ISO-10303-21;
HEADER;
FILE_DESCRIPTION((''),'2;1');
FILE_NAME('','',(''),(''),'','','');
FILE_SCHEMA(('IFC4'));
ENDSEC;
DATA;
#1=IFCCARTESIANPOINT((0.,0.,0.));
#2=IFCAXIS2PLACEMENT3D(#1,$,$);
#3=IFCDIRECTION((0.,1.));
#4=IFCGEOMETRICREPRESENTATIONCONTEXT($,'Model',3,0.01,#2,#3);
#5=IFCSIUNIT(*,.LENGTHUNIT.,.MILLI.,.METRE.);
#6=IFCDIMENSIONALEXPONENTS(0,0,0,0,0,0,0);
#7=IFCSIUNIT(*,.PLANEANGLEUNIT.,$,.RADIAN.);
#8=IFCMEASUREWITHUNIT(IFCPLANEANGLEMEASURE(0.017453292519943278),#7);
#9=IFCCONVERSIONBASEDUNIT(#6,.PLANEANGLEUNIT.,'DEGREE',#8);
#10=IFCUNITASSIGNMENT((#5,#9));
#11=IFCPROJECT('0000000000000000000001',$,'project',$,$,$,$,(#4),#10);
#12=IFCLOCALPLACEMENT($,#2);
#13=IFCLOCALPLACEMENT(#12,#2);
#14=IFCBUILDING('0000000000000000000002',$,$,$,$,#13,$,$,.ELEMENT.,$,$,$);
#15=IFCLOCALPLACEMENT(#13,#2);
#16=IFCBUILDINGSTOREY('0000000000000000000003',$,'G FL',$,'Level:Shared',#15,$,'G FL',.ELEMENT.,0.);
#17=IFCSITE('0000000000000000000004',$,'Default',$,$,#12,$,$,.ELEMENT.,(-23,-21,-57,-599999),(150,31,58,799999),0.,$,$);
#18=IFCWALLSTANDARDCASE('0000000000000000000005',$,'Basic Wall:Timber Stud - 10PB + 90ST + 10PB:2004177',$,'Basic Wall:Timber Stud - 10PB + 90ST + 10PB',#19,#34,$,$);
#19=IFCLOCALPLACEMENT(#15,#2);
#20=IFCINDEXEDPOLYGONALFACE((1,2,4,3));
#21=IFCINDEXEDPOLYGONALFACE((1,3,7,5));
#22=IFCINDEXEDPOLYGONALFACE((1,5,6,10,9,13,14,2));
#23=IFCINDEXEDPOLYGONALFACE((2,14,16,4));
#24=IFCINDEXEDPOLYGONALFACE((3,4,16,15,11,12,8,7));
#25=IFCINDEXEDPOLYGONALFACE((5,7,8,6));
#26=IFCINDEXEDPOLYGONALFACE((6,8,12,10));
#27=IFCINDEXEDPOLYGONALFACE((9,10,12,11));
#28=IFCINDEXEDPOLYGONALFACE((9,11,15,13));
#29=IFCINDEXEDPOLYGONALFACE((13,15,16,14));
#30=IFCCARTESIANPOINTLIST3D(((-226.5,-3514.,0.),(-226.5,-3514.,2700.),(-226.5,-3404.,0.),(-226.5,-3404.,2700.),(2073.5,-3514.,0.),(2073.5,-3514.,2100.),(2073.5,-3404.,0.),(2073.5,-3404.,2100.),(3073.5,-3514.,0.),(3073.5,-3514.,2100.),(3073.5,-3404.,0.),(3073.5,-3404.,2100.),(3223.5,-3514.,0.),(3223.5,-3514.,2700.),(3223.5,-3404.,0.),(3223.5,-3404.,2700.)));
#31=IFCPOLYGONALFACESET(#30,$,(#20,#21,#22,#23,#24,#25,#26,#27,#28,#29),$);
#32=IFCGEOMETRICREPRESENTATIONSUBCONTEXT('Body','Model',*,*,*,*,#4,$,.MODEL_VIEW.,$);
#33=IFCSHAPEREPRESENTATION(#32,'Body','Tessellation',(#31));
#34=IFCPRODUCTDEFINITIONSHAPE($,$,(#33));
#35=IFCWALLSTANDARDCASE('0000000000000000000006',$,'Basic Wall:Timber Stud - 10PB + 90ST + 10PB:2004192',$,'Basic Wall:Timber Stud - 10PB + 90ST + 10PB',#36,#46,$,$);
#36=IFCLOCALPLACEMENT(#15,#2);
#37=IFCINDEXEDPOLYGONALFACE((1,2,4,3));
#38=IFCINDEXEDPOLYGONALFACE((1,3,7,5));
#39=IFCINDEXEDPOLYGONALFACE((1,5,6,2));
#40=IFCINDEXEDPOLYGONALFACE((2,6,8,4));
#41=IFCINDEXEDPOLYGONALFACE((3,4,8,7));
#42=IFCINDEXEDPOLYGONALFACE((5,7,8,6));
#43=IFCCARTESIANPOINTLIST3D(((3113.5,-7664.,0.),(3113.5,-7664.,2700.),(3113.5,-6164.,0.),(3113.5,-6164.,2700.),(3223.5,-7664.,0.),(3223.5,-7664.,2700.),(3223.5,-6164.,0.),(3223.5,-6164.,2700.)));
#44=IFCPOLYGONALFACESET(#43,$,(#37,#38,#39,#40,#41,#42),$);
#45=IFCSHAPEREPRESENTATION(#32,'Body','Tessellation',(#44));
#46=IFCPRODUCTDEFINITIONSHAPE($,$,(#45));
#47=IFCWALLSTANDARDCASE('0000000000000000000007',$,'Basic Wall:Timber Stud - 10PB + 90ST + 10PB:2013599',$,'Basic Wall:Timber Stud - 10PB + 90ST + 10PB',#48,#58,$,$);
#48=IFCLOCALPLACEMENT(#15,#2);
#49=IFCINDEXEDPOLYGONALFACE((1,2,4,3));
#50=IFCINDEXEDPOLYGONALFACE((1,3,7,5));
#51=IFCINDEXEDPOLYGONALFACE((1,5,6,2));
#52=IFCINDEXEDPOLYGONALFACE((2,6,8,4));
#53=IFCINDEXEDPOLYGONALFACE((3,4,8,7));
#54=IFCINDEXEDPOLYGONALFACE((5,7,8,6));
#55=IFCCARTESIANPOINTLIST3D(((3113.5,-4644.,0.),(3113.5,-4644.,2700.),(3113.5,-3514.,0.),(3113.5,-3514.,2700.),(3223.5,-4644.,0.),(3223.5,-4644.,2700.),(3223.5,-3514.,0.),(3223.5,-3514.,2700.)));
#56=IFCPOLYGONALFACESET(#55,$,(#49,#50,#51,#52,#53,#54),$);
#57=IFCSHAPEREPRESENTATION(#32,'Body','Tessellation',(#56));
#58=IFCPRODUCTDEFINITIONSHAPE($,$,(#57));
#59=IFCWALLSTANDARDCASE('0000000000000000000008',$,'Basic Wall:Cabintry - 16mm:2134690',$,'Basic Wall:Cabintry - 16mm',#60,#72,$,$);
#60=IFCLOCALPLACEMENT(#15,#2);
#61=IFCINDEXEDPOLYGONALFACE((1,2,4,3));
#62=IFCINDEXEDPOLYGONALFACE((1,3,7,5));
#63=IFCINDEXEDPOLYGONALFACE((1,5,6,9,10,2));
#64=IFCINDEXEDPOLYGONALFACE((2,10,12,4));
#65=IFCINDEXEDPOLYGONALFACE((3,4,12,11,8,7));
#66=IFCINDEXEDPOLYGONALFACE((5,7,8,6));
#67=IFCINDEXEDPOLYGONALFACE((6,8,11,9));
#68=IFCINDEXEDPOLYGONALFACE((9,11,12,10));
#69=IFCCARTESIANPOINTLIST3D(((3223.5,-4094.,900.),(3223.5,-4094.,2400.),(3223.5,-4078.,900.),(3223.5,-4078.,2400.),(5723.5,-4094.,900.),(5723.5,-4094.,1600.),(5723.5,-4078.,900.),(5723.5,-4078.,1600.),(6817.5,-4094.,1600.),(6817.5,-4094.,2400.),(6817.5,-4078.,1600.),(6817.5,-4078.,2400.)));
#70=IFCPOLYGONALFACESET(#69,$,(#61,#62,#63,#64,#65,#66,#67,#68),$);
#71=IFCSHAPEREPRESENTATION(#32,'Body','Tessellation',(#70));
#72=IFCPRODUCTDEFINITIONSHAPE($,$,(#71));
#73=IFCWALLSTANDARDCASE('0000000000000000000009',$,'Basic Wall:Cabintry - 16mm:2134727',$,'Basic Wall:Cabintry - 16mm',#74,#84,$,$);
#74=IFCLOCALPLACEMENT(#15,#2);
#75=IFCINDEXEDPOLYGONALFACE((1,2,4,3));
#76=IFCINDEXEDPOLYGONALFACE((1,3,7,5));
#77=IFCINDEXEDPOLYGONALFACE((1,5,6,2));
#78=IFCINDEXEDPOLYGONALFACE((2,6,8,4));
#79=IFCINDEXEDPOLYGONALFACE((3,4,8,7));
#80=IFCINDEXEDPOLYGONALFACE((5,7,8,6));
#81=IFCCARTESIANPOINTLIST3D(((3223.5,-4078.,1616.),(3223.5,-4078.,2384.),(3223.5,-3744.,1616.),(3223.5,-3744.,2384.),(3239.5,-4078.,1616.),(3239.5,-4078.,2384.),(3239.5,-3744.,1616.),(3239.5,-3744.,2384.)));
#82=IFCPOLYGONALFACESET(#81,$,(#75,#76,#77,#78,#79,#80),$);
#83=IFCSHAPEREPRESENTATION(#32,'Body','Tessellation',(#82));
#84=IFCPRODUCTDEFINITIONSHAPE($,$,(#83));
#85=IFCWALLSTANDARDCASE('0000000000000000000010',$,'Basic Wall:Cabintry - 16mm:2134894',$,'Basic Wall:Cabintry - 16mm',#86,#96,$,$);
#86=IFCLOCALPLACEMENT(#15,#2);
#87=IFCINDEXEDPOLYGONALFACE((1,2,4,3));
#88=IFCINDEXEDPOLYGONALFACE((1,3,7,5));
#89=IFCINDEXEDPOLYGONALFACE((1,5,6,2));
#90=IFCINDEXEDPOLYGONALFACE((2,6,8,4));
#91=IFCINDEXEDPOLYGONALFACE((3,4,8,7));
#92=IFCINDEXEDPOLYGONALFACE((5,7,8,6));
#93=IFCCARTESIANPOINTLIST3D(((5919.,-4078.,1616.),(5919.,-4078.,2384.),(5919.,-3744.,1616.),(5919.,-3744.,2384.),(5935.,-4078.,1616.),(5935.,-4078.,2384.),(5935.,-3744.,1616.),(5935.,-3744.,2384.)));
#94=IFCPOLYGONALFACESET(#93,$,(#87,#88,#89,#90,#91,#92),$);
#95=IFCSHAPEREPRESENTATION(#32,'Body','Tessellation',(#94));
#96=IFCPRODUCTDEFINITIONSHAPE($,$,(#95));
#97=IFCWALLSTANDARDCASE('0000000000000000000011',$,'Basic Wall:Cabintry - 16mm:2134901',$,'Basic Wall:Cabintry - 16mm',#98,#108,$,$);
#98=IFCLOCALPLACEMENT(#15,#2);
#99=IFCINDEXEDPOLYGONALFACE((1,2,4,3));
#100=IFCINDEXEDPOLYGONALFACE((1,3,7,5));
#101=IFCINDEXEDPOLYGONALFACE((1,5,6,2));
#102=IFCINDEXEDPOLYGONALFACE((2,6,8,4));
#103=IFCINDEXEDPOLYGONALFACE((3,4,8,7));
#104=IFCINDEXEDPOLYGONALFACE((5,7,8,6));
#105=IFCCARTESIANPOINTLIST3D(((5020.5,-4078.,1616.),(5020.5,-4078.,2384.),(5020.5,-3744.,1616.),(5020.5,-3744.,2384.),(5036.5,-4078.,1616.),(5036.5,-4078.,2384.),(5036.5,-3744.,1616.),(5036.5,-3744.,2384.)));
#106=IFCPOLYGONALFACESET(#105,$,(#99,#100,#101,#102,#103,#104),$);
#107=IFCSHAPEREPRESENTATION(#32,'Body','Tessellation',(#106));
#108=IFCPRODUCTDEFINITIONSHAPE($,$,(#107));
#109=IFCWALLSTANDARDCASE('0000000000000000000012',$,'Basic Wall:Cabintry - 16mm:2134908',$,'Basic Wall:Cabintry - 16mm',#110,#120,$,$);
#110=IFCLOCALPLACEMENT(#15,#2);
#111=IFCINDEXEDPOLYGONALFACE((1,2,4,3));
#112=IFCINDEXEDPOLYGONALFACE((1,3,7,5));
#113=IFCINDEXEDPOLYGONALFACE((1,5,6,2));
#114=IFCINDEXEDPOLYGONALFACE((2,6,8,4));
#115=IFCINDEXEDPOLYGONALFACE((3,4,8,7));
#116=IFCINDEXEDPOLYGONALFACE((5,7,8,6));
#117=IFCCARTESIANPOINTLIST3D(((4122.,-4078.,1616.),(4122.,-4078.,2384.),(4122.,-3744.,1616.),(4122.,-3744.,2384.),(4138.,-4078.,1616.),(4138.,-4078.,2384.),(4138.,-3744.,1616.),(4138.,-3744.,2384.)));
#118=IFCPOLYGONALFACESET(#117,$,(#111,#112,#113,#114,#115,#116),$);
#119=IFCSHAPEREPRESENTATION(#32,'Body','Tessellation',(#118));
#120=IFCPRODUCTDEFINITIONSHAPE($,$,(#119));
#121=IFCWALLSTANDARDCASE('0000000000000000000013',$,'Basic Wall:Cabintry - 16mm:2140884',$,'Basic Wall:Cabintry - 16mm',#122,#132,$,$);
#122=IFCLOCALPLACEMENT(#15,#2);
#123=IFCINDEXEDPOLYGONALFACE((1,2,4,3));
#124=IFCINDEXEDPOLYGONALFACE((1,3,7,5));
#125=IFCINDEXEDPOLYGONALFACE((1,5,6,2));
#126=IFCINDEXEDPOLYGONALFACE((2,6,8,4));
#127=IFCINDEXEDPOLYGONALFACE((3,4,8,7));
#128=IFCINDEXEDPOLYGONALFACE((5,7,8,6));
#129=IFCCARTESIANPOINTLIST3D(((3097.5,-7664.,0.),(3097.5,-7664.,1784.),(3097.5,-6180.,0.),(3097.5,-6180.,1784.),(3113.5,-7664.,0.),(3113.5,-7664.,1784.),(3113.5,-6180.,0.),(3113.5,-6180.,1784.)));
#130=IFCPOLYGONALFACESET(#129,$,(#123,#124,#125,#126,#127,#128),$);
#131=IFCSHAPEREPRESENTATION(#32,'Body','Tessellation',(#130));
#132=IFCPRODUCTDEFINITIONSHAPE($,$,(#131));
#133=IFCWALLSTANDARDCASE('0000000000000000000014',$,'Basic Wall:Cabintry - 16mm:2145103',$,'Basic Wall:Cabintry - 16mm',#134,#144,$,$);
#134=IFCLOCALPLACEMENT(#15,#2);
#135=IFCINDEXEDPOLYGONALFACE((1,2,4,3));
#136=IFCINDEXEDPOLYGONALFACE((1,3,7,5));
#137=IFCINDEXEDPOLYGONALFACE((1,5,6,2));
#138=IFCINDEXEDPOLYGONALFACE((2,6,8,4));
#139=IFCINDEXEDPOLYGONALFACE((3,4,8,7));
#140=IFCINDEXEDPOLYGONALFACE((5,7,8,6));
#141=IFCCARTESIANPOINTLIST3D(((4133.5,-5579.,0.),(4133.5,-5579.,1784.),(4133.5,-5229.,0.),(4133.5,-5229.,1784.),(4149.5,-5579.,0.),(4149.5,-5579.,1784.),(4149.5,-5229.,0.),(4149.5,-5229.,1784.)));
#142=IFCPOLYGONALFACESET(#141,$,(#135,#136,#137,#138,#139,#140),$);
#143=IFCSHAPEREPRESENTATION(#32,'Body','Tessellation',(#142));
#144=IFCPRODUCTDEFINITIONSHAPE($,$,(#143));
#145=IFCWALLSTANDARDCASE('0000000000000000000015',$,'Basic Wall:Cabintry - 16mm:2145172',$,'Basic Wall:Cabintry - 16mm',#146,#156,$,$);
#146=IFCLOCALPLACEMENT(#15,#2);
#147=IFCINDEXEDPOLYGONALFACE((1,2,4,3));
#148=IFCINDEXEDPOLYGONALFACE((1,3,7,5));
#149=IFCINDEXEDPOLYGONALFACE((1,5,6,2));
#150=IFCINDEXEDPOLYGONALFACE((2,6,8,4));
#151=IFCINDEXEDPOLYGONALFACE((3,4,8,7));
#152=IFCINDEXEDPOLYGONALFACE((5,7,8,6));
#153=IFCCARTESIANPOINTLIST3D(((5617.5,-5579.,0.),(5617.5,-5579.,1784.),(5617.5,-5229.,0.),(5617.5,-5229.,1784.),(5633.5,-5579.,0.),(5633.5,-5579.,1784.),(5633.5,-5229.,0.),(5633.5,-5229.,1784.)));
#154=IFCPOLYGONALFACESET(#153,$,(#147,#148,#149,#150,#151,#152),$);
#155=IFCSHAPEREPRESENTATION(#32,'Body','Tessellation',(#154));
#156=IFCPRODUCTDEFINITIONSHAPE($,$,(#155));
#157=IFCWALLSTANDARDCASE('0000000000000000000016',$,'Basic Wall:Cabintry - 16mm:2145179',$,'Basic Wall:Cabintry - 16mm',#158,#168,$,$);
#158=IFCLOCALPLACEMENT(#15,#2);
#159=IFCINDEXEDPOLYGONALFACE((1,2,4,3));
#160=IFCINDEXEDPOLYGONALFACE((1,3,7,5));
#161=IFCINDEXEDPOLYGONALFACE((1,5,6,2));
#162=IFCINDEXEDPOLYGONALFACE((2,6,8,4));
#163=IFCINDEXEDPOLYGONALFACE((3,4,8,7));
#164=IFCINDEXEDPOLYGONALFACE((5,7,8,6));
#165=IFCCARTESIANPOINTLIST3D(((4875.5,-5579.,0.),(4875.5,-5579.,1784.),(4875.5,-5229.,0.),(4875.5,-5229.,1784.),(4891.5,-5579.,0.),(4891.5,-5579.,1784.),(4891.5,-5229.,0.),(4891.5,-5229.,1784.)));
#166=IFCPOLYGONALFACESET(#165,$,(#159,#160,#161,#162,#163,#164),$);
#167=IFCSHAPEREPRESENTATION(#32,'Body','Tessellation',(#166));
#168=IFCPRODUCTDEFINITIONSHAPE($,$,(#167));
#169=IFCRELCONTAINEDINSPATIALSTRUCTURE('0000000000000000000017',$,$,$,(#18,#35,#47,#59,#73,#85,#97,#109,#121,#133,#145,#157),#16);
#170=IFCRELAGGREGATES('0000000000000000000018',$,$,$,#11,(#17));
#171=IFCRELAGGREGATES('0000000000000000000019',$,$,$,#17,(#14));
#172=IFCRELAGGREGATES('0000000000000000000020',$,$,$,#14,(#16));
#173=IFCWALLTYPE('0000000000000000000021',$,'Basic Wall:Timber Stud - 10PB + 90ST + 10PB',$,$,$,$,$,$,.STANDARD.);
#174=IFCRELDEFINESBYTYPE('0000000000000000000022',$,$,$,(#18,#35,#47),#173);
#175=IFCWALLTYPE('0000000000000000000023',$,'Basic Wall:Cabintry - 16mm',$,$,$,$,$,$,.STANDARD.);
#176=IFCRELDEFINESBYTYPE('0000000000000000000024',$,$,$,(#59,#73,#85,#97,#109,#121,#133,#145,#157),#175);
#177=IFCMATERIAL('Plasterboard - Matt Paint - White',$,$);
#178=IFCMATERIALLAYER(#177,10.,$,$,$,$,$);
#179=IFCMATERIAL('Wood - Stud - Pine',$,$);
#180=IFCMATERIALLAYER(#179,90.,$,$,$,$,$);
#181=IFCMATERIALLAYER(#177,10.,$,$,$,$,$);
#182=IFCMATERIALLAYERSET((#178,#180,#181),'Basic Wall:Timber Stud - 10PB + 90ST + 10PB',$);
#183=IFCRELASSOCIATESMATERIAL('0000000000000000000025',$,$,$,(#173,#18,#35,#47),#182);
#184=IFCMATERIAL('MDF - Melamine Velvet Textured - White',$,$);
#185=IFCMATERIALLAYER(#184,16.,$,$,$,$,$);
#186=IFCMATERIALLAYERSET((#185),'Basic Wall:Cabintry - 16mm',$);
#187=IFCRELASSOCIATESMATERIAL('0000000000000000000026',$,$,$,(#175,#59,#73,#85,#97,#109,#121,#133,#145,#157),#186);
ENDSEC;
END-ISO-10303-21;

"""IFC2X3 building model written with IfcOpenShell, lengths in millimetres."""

from ifc_helpers import new_model, entity, si_unit, converted_unit, direction, frame, frame_2d, origin, place, context, subcontext, project, spatial, polyline, rectangle, extrude, clip, bounded_halfspace, material, layer, layer_set, layer_usage, type_object, element, save


model = new_model("IFC2X3")

# Units and contexts
model_context = context("Model", 3, precision=0.01, world=origin(), true_north=direction((0.0, 1.0)))
body_context = subcontext(model_context, "Body", "Model", "MODEL_VIEW")
ifc_project = project(units=[si_unit("LENGTHUNIT", "METRE", prefix="MILLI"), converted_unit("PLANEANGLEUNIT", "DEGREE", entity("IfcPlaneAngleMeasure", 0.017453292519943278), si_unit("PLANEANGLEUNIT", "RADIAN"), dimensions=[0, 0, 0, 0, 0, 0, 0])], contexts=[model_context])

# Site, building, storey
site_placement = place(None, origin())
site = spatial("IfcSite", under=ifc_project, at=site_placement, Name="Default", CompositionType="ELEMENT", RefLatitude=(-23, -21, -57, -599999), RefLongitude=(150, 31, 58, 799999), RefElevation=0.0)
building_placement = place(site_placement, origin())
building = spatial("IfcBuilding", under=site, at=building_placement, CompositionType="ELEMENT")
storey_placement = place(building_placement, origin())
storey = spatial("IfcBuildingStorey", under=building, at=storey_placement, Name="G FL", ObjectType="Level:Shared", LongName="G FL", CompositionType="ELEMENT", Elevation=0.0)

# Wall, opening
ifc_material_1 = material(Name="Plasterboard - Matt Paint - White")
ifc_layer_1 = layer(ifc_material_1, 10.0)
ifc_material_2 = material(Name="Wood - Stud - Pine")
ifc_layer_2 = layer(ifc_material_2, 90.0)
ifc_layer_3 = layer(ifc_material_1, 10.0)
ifc_layer_set_1 = layer_set([ifc_layer_1, ifc_layer_2, ifc_layer_3], Name="Basic Wall:Timber Stud - 10PB + 90ST + 10PB")
ifc_layer_usage_1 = layer_usage(ifc_layer_set_1, "AXIS2", "POSITIVE", -55.0)
wall_type_1 = type_object("IfcWallType", Name="Basic Wall:Timber Stud - 10PB + 90ST + 10PB", PredefinedType="STANDARD", material=ifc_layer_set_1)
wall_1_placement = place(storey_placement, frame((3223.5, -3459.0, 0.0), z_axis=(0.0, 0.0, 1.0), x_axis=(-1.0, 0.0, 0.0)))
wall_1 = element("IfcWallStandardCase", 1, at=wall_1_placement, inside=storey, type_object=wall_type_1, material=ifc_layer_usage_1, Name="Basic Wall:Timber Stud - 10PB + 90ST + 10PB:2004177", ObjectType="Basic Wall:Timber Stud - 10PB + 90ST + 10PB", context=body_context, shape_type="SweptSolid", body=[
    extrude(rectangle(XDim=3450.0, YDim=110.0, at=frame_2d((1725.0, 0.0), x_axis=(-1.0, 0.0))), origin(), (0.0, 0.0, 1.0), 2700.0),
])
opening_1_placement = place(wall_1_placement, frame((150.0, -55.0, 0.0)))
element("IfcOpeningElement", 2, at=opening_1_placement, cuts=wall_1, ObjectType="Opening", context=body_context, shape_type="SweptSolid", body=[
    extrude(rectangle(XDim=2100.0, YDim=1000.0, at=frame_2d((1050.0, 500.0), x_axis=(1.0, 0.0))), frame((0.0, 0.0, 0.0), z_axis=(0.0, 1.0, 0.0), x_axis=(0.0, 0.0, 1.0)), (0.0, 0.0, 1.0), 110.0),
])

# Walls
ifc_layer_usage_2 = layer_usage(ifc_layer_set_1, "AXIS2", "NEGATIVE", 55.0)
wall_2_placement = place(storey_placement, frame((3168.5, -6164.0, 0.0), z_axis=(0.0, 0.0, 1.0), x_axis=(0.0, -1.0, 0.0)))
element("IfcWallStandardCase", 3, at=wall_2_placement, inside=storey, type_object=wall_type_1, material=ifc_layer_usage_2, Name="Basic Wall:Timber Stud - 10PB + 90ST + 10PB:2004192", ObjectType="Basic Wall:Timber Stud - 10PB + 90ST + 10PB", context=body_context, shape_type="SweptSolid", body=[
    extrude(rectangle(XDim=1500.0, YDim=110.0, at=frame_2d((750.0, 0.0), x_axis=(-1.0, 0.0))), origin(), (0.0, 0.0, 1.0), 2700.0),
])
ifc_layer_usage_3 = layer_usage(ifc_layer_set_1, "AXIS2", "POSITIVE", -55.0)
wall_3_placement = place(storey_placement, frame((3168.5, -4644.0, 0.0), z_axis=(0.0, 0.0, 1.0), x_axis=(0.0, 1.0, 0.0)))
element("IfcWallStandardCase", 4, at=wall_3_placement, inside=storey, type_object=wall_type_1, material=ifc_layer_usage_3, Name="Basic Wall:Timber Stud - 10PB + 90ST + 10PB:2013599", ObjectType="Basic Wall:Timber Stud - 10PB + 90ST + 10PB", context=body_context, shape_type="SweptSolid", body=[
    extrude(rectangle(XDim=1130.0, YDim=110.0, at=frame_2d((565.0, 0.0), x_axis=(-1.0, 0.0))), origin(), (0.0, 0.0, 1.0), 2700.0),
])

# Wall, opening
ifc_material_3 = material(Name="MDF - Melamine Velvet Textured - White")
ifc_layer_4 = layer(ifc_material_3, 16.0)
ifc_layer_set_2 = layer_set([ifc_layer_4], Name="Basic Wall:Cabintry - 16mm")
ifc_layer_usage_4 = layer_usage(ifc_layer_set_2, "AXIS2", "NEGATIVE", 8.0)
wall_type_2 = type_object("IfcWallType", Name="Basic Wall:Cabintry - 16mm", PredefinedType="STANDARD", material=ifc_layer_set_2)
wall_4_placement = place(storey_placement, frame((6817.5, -4086.0, 900.0), z_axis=(0.0, 0.0, 1.0), x_axis=(-1.0, 0.0, 0.0)))
wall_4 = element("IfcWallStandardCase", 5, at=wall_4_placement, inside=storey, type_object=wall_type_2, material=ifc_layer_usage_4, Name="Basic Wall:Cabintry - 16mm:2134690", ObjectType="Basic Wall:Cabintry - 16mm", context=body_context, shape_type="SweptSolid", body=[
    extrude(rectangle(XDim=3594.0, YDim=16.0, at=frame_2d((1797.0, 0.0), x_axis=(-1.0, 0.0))), origin(), (0.0, 0.0, 1.0), 1500.0),
])
opening_2_placement = place(wall_4_placement, origin())
element("IfcOpeningElement", 6, at=opening_2_placement, cuts=wall_4, ObjectType="Opening", context=body_context, shape_type="SweptSolid", body=[
    extrude(rectangle(XDim=700.0, YDim=1102.0, at=frame_2d((0.0, 0.0), x_axis=(1.0, 0.0))), frame((543.0, 8.0, 350.0), z_axis=(0.0, -1.0, 0.0), x_axis=(0.0, 0.0, 1.0)), (0.0, 0.0, 1.0), 16.0),
])

# Walls
ifc_layer_usage_5 = layer_usage(ifc_layer_set_2, "AXIS2", "NEGATIVE", 8.0)
wall_5_placement = place(storey_placement, frame((3231.5, -4078.0, 1616.0), z_axis=(0.0, 0.0, 1.0), x_axis=(0.0, 1.0, 0.0)))
element("IfcWallStandardCase", 7, at=wall_5_placement, inside=storey, type_object=wall_type_2, material=ifc_layer_usage_5, Name="Basic Wall:Cabintry - 16mm:2134727", ObjectType="Basic Wall:Cabintry - 16mm", context=body_context, shape_type="SweptSolid", body=[
    extrude(rectangle(XDim=334.0, YDim=16.0, at=frame_2d((167.0, 0.0), x_axis=(-1.0, 0.0))), origin(), (0.0, 0.0, 1.0), 768.0),
])
ifc_layer_usage_6 = layer_usage(ifc_layer_set_2, "AXIS2", "NEGATIVE", 8.0)
wall_6_placement = place(storey_placement, frame((5927.0, -3744.0, 1616.0), z_axis=(0.0, 0.0, 1.0), x_axis=(0.0, -1.0, 0.0)))
element("IfcWallStandardCase", 8, at=wall_6_placement, inside=storey, type_object=wall_type_2, material=ifc_layer_usage_6, Name="Basic Wall:Cabintry - 16mm:2134894", ObjectType="Basic Wall:Cabintry - 16mm", context=body_context, shape_type="SweptSolid", body=[
    extrude(rectangle(XDim=334.0, YDim=16.0, at=frame_2d((167.0, 0.0), x_axis=(-1.0, 0.0))), origin(), (0.0, 0.0, 1.0), 768.0),
])
ifc_layer_usage_7 = layer_usage(ifc_layer_set_2, "AXIS2", "NEGATIVE", 8.0)
wall_7_placement = place(storey_placement, frame((5028.5, -3744.0, 1616.0), z_axis=(0.0, 0.0, 1.0), x_axis=(0.0, -1.0, 0.0)))
element("IfcWallStandardCase", 9, at=wall_7_placement, inside=storey, type_object=wall_type_2, material=ifc_layer_usage_7, Name="Basic Wall:Cabintry - 16mm:2134901", ObjectType="Basic Wall:Cabintry - 16mm", context=body_context, shape_type="SweptSolid", body=[
    extrude(rectangle(XDim=334.0, YDim=16.0, at=frame_2d((167.0, 0.0), x_axis=(-1.0, 0.0))), origin(), (0.0, 0.0, 1.0), 768.0),
])
ifc_layer_usage_8 = layer_usage(ifc_layer_set_2, "AXIS2", "NEGATIVE", 8.0)
wall_8_placement = place(storey_placement, frame((4130.0, -3744.0, 1616.0), z_axis=(0.0, 0.0, 1.0), x_axis=(0.0, -1.0, 0.0)))
element("IfcWallStandardCase", 10, at=wall_8_placement, inside=storey, type_object=wall_type_2, material=ifc_layer_usage_8, Name="Basic Wall:Cabintry - 16mm:2134908", ObjectType="Basic Wall:Cabintry - 16mm", context=body_context, shape_type="SweptSolid", body=[
    extrude(rectangle(XDim=334.0, YDim=16.0, at=frame_2d((167.0, 0.0), x_axis=(-1.0, 0.0))), origin(), (0.0, 0.0, 1.0), 768.0),
])
ifc_layer_usage_9 = layer_usage(ifc_layer_set_2, "AXIS2", "NEGATIVE", 8.0)
wall_9_placement = place(storey_placement, frame((3105.5, -6180.0, 0.0), z_axis=(0.0, 0.0, 1.0), x_axis=(0.0, -1.0, 0.0)))
element("IfcWallStandardCase", 11, at=wall_9_placement, inside=storey, type_object=wall_type_2, material=ifc_layer_usage_9, Name="Basic Wall:Cabintry - 16mm:2140884", ObjectType="Basic Wall:Cabintry - 16mm", context=body_context, shape_type="Clipping", body=[
    clip(extrude(rectangle(XDim=1484.0, YDim=16.0, at=frame_2d((742.0, 0.0), x_axis=(-1.0, 0.0))), origin(), (0.0, 0.0, 1.0), 1784.0), bounded_halfspace(frame((0.0, -8.0, 1784.0), z_axis=(0.0, 0.0, -1.0), x_axis=(0.0, 1.0, 0.0)), True, frame((0.0, -8.0, 1784.0)), polyline([(0.0, 0.0), (726.0, 0.0), (742.0, 0.0), (1468.0, 0.0), (1484.0, 0.0), (1484.0, 16.0), (0.0, 16.0), (0.0, 0.0)]))),
])
ifc_layer_usage_10 = layer_usage(ifc_layer_set_2, "AXIS2", "NEGATIVE", 8.0)
wall_10_placement = place(storey_placement, frame((4141.5, -5229.0, 0.0), z_axis=(0.0, 0.0, 1.0), x_axis=(0.0, -1.0, 0.0)))
element("IfcWallStandardCase", 12, at=wall_10_placement, inside=storey, type_object=wall_type_2, material=ifc_layer_usage_10, Name="Basic Wall:Cabintry - 16mm:2145103", ObjectType="Basic Wall:Cabintry - 16mm", context=body_context, shape_type="SweptSolid", body=[
    extrude(rectangle(XDim=350.0, YDim=16.0, at=frame_2d((175.0, 0.0), x_axis=(-1.0, 0.0))), origin(), (0.0, 0.0, 1.0), 1784.0),
])
ifc_layer_usage_11 = layer_usage(ifc_layer_set_2, "AXIS2", "NEGATIVE", 8.0)
wall_11_placement = place(storey_placement, frame((5625.5, -5229.0, 0.0), z_axis=(0.0, 0.0, 1.0), x_axis=(0.0, -1.0, 0.0)))
element("IfcWallStandardCase", 13, at=wall_11_placement, inside=storey, type_object=wall_type_2, material=ifc_layer_usage_11, Name="Basic Wall:Cabintry - 16mm:2145172", ObjectType="Basic Wall:Cabintry - 16mm", context=body_context, shape_type="SweptSolid", body=[
    extrude(rectangle(XDim=350.0, YDim=16.0, at=frame_2d((175.0, 0.0), x_axis=(-1.0, 0.0))), origin(), (0.0, 0.0, 1.0), 1784.0),
])
ifc_layer_usage_12 = layer_usage(ifc_layer_set_2, "AXIS2", "NEGATIVE", 8.0)
wall_12_placement = place(storey_placement, frame((4883.5, -5229.0, 0.0), z_axis=(0.0, 0.0, 1.0), x_axis=(0.0, -1.0, 0.0)))
element("IfcWallStandardCase", 14, at=wall_12_placement, inside=storey, type_object=wall_type_2, material=ifc_layer_usage_12, Name="Basic Wall:Cabintry - 16mm:2145179", ObjectType="Basic Wall:Cabintry - 16mm", context=body_context, shape_type="SweptSolid", body=[
    extrude(rectangle(XDim=350.0, YDim=16.0, at=frame_2d((175.0, 0.0), x_axis=(-1.0, 0.0))), origin(), (0.0, 0.0, 1.0), 1784.0),
])

save(model, "model.ifc")
